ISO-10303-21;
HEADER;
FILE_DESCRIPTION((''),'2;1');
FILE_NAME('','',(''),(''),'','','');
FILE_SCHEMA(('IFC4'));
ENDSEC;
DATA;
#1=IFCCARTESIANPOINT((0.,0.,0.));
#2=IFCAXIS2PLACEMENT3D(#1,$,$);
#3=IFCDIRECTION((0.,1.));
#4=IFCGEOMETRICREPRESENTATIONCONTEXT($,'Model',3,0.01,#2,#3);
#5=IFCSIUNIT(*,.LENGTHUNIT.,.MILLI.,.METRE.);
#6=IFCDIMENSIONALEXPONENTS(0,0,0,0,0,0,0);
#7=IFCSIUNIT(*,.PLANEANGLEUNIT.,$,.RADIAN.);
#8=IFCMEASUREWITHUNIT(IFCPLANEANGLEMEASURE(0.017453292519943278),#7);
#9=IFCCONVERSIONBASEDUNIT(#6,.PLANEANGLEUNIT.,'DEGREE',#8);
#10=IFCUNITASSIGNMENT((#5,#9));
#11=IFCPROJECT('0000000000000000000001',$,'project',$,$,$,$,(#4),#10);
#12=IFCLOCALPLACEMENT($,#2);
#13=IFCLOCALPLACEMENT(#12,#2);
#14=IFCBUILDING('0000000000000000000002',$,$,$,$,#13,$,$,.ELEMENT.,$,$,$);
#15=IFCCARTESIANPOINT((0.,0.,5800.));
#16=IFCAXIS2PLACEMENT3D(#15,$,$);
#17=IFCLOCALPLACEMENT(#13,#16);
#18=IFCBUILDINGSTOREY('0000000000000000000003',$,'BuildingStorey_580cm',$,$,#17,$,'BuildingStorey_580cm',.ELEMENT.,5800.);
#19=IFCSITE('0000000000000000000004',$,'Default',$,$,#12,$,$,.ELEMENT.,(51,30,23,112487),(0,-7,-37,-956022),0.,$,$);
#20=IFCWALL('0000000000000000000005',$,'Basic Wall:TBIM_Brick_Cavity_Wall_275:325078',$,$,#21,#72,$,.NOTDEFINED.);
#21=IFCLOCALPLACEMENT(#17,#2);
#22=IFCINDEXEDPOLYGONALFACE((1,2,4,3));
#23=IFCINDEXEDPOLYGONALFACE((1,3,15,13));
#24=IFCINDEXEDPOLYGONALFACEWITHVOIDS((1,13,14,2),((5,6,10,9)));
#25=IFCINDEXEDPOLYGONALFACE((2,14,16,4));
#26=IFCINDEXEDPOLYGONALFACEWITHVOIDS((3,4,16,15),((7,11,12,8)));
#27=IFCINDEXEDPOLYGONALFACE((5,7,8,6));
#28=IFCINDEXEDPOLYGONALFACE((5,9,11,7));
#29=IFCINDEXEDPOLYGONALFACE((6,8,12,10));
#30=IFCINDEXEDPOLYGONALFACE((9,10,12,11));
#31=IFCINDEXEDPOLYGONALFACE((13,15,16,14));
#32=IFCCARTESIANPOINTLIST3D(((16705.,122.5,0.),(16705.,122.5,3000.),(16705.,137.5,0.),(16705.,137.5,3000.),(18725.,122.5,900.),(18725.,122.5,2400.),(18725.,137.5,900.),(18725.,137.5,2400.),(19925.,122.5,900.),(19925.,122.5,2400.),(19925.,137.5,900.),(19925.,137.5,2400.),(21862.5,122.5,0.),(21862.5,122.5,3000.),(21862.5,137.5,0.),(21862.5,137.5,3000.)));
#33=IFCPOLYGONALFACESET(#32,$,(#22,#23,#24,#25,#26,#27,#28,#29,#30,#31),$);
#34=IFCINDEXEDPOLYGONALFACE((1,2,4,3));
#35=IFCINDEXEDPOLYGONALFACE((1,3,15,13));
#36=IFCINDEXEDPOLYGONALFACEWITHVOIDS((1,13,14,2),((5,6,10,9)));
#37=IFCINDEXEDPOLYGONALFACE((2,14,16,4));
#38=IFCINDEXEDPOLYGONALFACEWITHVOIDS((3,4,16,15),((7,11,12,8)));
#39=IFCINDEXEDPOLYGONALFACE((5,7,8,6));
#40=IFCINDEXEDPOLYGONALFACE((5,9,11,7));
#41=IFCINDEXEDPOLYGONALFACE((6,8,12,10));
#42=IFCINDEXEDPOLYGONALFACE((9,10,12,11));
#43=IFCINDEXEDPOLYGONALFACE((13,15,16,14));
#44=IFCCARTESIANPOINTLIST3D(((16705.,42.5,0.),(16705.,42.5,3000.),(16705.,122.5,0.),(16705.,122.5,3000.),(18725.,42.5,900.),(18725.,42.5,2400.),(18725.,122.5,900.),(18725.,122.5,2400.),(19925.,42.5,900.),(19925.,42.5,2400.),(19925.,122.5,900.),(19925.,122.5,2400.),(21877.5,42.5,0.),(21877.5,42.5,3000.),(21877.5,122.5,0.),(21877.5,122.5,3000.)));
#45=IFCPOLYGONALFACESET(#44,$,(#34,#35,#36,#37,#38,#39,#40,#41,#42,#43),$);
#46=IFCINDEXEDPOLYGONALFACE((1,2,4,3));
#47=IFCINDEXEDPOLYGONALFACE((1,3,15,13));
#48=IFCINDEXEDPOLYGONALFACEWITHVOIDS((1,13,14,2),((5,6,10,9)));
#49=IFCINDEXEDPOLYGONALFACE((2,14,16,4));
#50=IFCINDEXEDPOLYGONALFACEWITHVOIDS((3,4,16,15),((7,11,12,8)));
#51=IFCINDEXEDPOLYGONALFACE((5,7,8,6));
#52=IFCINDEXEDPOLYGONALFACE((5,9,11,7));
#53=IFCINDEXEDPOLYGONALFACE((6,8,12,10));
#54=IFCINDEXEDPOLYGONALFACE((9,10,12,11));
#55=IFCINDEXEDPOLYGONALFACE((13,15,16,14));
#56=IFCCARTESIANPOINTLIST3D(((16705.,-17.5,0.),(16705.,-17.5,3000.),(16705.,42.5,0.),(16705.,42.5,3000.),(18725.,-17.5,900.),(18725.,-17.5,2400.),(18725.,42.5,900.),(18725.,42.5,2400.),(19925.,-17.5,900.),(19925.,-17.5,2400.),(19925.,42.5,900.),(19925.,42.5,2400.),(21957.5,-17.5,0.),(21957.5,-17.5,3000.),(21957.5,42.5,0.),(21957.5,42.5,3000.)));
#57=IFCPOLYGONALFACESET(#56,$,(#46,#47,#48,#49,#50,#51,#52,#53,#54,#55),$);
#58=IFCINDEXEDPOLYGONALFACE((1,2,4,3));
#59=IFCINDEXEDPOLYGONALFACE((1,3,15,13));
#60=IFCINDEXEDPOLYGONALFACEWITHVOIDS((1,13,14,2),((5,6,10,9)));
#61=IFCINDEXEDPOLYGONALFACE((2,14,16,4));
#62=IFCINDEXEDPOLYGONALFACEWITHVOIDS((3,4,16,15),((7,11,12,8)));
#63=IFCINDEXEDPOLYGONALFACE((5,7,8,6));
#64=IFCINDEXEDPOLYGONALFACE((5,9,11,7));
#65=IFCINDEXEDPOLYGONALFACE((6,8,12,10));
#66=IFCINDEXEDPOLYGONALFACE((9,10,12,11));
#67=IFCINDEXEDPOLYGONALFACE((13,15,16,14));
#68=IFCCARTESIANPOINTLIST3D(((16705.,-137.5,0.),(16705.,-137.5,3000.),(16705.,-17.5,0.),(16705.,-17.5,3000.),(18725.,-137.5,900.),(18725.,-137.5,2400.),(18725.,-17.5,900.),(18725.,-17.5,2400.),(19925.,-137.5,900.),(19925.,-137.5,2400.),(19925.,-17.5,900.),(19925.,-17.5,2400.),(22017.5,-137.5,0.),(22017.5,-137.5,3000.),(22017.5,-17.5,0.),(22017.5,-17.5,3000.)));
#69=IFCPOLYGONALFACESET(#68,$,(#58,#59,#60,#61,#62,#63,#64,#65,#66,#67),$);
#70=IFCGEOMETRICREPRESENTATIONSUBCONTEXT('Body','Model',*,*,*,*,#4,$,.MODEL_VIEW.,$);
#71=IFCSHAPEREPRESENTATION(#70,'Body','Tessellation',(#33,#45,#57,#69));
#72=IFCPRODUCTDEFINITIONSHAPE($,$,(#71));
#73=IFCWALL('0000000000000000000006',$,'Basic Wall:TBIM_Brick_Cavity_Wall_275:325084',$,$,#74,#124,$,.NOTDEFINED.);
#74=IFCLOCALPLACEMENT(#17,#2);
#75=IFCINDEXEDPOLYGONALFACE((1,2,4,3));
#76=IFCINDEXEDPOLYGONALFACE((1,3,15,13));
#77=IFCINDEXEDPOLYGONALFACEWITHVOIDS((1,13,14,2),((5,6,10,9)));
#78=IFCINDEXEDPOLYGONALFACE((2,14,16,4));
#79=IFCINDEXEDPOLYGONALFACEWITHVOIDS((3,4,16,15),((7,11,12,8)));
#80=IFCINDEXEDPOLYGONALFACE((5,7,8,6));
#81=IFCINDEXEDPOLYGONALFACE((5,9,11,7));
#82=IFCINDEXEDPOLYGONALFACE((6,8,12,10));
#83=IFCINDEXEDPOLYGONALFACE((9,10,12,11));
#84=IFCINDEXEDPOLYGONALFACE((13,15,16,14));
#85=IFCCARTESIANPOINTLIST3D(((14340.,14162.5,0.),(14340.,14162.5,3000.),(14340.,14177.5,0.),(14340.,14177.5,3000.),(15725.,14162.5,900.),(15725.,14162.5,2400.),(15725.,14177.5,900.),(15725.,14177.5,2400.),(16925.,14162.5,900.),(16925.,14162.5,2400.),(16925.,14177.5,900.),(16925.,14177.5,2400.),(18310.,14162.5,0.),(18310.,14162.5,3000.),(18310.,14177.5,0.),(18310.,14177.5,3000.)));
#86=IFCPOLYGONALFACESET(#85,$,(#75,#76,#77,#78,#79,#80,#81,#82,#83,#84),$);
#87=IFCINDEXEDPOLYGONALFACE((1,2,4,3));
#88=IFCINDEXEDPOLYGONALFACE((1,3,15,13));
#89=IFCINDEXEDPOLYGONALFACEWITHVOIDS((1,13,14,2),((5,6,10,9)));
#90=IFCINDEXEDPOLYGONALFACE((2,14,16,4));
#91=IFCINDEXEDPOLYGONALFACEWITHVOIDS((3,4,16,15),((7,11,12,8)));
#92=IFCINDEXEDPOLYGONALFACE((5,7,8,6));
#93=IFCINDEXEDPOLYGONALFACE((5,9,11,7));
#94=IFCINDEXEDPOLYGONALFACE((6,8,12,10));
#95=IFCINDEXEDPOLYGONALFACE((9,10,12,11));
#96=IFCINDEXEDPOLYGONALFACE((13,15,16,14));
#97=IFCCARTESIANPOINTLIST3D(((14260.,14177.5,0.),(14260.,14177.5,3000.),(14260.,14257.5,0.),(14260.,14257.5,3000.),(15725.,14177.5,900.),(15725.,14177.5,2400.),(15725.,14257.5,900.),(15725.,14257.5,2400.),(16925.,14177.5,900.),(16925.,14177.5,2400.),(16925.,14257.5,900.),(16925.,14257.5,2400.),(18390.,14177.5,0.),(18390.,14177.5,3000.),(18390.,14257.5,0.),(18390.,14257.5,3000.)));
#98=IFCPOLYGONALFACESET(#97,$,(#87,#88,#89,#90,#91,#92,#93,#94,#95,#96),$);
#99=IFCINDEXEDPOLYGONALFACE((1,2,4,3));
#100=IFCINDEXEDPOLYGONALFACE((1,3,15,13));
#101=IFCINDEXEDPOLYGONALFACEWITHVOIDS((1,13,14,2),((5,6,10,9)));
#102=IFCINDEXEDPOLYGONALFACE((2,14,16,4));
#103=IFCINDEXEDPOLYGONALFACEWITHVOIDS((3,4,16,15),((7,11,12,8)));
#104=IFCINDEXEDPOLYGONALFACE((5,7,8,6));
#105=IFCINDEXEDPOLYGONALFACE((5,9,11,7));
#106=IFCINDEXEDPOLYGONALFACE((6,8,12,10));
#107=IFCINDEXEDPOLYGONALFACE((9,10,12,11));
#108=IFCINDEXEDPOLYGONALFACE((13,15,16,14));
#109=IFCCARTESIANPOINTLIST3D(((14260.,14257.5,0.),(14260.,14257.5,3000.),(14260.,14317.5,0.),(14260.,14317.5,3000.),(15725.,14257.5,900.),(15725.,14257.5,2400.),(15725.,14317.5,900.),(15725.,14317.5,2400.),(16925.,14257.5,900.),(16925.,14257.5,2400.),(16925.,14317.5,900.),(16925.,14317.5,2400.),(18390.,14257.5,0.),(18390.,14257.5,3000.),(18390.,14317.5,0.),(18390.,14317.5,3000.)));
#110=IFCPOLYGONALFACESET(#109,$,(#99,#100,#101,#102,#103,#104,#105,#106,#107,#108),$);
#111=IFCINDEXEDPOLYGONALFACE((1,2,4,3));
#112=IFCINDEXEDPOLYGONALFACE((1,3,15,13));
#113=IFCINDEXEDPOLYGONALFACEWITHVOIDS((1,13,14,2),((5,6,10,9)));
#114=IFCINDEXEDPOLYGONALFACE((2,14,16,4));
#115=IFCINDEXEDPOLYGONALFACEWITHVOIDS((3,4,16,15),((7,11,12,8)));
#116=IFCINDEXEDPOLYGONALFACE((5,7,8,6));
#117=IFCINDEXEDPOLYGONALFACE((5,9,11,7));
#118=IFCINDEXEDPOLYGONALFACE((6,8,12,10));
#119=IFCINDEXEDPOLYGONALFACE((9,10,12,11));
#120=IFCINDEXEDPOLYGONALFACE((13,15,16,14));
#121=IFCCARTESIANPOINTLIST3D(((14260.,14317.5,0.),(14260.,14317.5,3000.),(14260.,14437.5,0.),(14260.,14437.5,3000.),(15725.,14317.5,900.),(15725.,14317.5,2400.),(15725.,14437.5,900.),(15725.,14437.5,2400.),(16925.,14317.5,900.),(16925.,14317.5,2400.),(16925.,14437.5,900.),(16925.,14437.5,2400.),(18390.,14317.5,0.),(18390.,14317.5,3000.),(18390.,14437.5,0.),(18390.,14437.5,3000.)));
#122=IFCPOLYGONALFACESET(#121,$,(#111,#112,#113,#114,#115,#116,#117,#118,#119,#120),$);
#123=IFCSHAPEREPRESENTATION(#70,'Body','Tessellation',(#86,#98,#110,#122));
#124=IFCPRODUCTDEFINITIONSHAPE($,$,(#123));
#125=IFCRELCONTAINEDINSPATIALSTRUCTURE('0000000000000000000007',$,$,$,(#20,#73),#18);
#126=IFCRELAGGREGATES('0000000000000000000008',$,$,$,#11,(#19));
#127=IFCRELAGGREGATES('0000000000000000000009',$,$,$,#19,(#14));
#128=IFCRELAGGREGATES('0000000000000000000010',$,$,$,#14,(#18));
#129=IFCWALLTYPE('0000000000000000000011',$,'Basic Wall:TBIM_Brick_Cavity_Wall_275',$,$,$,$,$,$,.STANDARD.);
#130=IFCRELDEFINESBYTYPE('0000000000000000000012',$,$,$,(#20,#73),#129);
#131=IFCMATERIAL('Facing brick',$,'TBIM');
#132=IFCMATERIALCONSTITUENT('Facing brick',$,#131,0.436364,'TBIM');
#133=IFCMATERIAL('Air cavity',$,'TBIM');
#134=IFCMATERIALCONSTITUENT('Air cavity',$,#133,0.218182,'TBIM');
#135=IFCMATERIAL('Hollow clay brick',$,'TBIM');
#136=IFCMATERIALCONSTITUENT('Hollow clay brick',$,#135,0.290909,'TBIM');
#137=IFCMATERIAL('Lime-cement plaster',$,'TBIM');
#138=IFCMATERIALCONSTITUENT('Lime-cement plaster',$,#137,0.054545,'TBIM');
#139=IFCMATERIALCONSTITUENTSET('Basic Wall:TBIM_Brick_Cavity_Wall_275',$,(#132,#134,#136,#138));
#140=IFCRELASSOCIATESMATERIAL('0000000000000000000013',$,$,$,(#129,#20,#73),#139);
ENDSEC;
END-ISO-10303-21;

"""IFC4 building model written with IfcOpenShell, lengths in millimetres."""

from ifc_helpers import new_model, entity, si_unit, converted_unit, direction, frame, origin, place, context, subcontext, project, spatial, indexed_curve, outline, extrude, material, constituent, constituent_set, type_object, element, save


model = new_model("IFC4")

# Units and contexts
model_context = context("Model", 3, precision=0.01, world=origin(), true_north=direction((0.0, 1.0)))
body_context = subcontext(model_context, "Body", "Model", "MODEL_VIEW")
ifc_project = project(units=[si_unit("LENGTHUNIT", "METRE", prefix="MILLI"), converted_unit("PLANEANGLEUNIT", "DEGREE", entity("IfcPlaneAngleMeasure", 0.017453292519943278), si_unit("PLANEANGLEUNIT", "RADIAN"), dimensions=[0, 0, 0, 0, 0, 0, 0])], contexts=[model_context])

# Site, building, storey
site_placement = place(None, origin())
site = spatial("IfcSite", under=ifc_project, at=site_placement, Name="Default", CompositionType="ELEMENT", RefLatitude=(51, 30, 23, 112487), RefLongitude=(0, -7, -37, -956022), RefElevation=0.0)
building_placement = place(site_placement, origin())
building = spatial("IfcBuilding", under=site, at=building_placement, CompositionType="ELEMENT")
storey_placement = place(building_placement, frame((0.0, 0.0, 5800.0)))
storey = spatial("IfcBuildingStorey", under=building, at=storey_placement, Name="BuildingStorey_580cm", LongName="BuildingStorey_580cm", CompositionType="ELEMENT", Elevation=5800.0)

# Walls, openings
ifc_material_1 = material(Name="Facing brick", Category="TBIM")
ifc_constituent_1 = constituent(ifc_material_1, Name="Facing brick", Category="TBIM", fraction=0.436364)
ifc_material_2 = material(Name="Air cavity", Category="TBIM")
ifc_constituent_2 = constituent(ifc_material_2, Name="Air cavity", Category="TBIM", fraction=0.218182)
ifc_material_3 = material(Name="Hollow clay brick", Category="TBIM")
ifc_constituent_3 = constituent(ifc_material_3, Name="Hollow clay brick", Category="TBIM", fraction=0.290909)
ifc_material_4 = material(Name="Lime-cement plaster", Category="TBIM")
ifc_constituent_4 = constituent(ifc_material_4, Name="Lime-cement plaster", Category="TBIM", fraction=0.054545)
ifc_constituent_set_1 = constituent_set(constituents=[ifc_constituent_1, ifc_constituent_2, ifc_constituent_3, ifc_constituent_4], Name="Basic Wall:TBIM_Brick_Cavity_Wall_275")
wall_type_1 = type_object("IfcWallType", Name="Basic Wall:TBIM_Brick_Cavity_Wall_275", PredefinedType="STANDARD", material=ifc_constituent_set_1)
wall_1_placement = place(storey_placement, frame((16705.0, 0.0, 0.0)))
wall_1 = element("IfcWall", 1, at=wall_1_placement, inside=storey, type_object=wall_type_1, material=ifc_constituent_set_1, Name="Basic Wall:TBIM_Brick_Cavity_Wall_275:325078", PredefinedType="NOTDEFINED", context=body_context, shape_type="SweptSolid", body=[
    extrude(outline(indexed_curve([(-1500.0, -2578.8), (1500.0, -2578.8), (1500.0, 2578.8), (-1500.0, 2578.8), (-1500.0, -2578.8)], self_intersect=False), holes=[indexed_curve([(-600.0, -558.8), (-600.0, 641.2), (900.0, 641.2), (900.0, -558.8), (-600.0, -558.8)], self_intersect=False)]), frame((2578.8, 122.5, 1500.0), z_axis=(0.0, 1.0, 0.0), x_axis=(0.0, 0.0, 1.0)), (0.0, 0.0, 1.0), 15.0),
    extrude(outline(indexed_curve([(-1500.0, -2586.3), (1500.0, -2586.3), (1500.0, 2586.3), (-1500.0, 2586.3), (-1500.0, -2586.3)], self_intersect=False), holes=[indexed_curve([(-600.0, -566.3), (-600.0, 633.7), (900.0, 633.7), (900.0, -566.3), (-600.0, -566.3)], self_intersect=False)]), frame((2586.3, 42.5, 1500.0), z_axis=(0.0, 1.0, 0.0), x_axis=(0.0, 0.0, 1.0)), (0.0, 0.0, 1.0), 80.0),
    extrude(outline(indexed_curve([(-1500.0, -2626.3), (1500.0, -2626.3), (1500.0, 2626.3), (-1500.0, 2626.3), (-1500.0, -2626.3)], self_intersect=False), holes=[indexed_curve([(-600.0, -606.3), (-600.0, 593.7), (900.0, 593.7), (900.0, -606.3), (-600.0, -606.3)], self_intersect=False)]), frame((2626.3, -17.5, 1500.0), z_axis=(0.0, 1.0, 0.0), x_axis=(0.0, 0.0, 1.0)), (0.0, 0.0, 1.0), 60.0),
    extrude(outline(indexed_curve([(-1500.0, -2656.3), (1500.0, -2656.3), (1500.0, 2656.3), (-1500.0, 2656.3), (-1500.0, -2656.3)], self_intersect=False), holes=[indexed_curve([(900.0, -636.3), (-600.0, -636.3), (-600.0, 563.7), (900.0, 563.7), (900.0, -636.3)], self_intersect=False)]), frame((2656.3, -137.5, 1500.0), z_axis=(0.0, 1.0, 0.0), x_axis=(0.0, 0.0, 1.0)), (0.0, 0.0, 1.0), 120.0),
])
opening_1_placement = place(wall_1_placement, frame((2020.0, -137.5, 900.0)))
element("IfcOpeningElement", 2, at=opening_1_placement, cuts=wall_1, PredefinedType="OPENING", context=body_context, shape_type="SweptSolid", body=[
    extrude(outline(indexed_curve([(1500.0, 0.0), (1500.0, 1200.0), (0.0, 1200.0), (0.0, 0.0), (1500.0, 0.0)], self_intersect=False)), frame((0.0, 0.0, 0.0), z_axis=(0.0, 1.0, 0.0), x_axis=(0.0, 0.0, 1.0)), (0.0, 0.0, 1.0), 275.0),
])
wall_2_placement = place(storey_placement, frame((14245.0, 14300.0, 0.0)))
wall_2 = element("IfcWall", 3, at=wall_2_placement, inside=storey, type_object=wall_type_1, material=ifc_constituent_set_1, Name="Basic Wall:TBIM_Brick_Cavity_Wall_275:325084", PredefinedType="NOTDEFINED", context=body_context, shape_type="SweptSolid", body=[
    extrude(outline(indexed_curve([(-1500.0, -1985.0), (1500.0, -1985.0), (1500.0, -1970.0), (1500.0, 1970.0), (1500.0, 1985.0), (-1500.0, 1985.0), (-1500.0, 1970.0), (-1500.0, -1970.0), (-1500.0, -1985.0)], self_intersect=False), holes=[indexed_curve([(900.0, -600.0), (-600.0, -600.0), (-600.0, 600.0), (900.0, 600.0), (900.0, -600.0)], self_intersect=False)]), frame((2080.0, -137.5, 1500.0), z_axis=(0.0, 1.0, 0.0), x_axis=(0.0, 0.0, 1.0)), (0.0, 0.0, 1.0), 15.0),
    extrude(outline(indexed_curve([(-1500.0, -2065.0), (1500.0, -2065.0), (1500.0, 2065.0), (-1500.0, 2065.0), (-1500.0, -2065.0)], self_intersect=False), holes=[indexed_curve([(-600.0, -600.0), (-600.0, 600.0), (900.0, 600.0), (900.0, -600.0), (-600.0, -600.0)], self_intersect=False)]), frame((2080.0, -122.5, 1500.0), z_axis=(0.0, 1.0, 0.0), x_axis=(0.0, 0.0, 1.0)), (0.0, 0.0, 1.0), 80.0),
    extrude(outline(indexed_curve([(-1500.0, -2065.0), (1500.0, -2065.0), (1500.0, 2065.0), (-1500.0, 2065.0), (-1500.0, -2065.0)], self_intersect=False), holes=[indexed_curve([(-600.0, -600.0), (-600.0, 600.0), (900.0, 600.0), (900.0, -600.0), (-600.0, -600.0)], self_intersect=False)]), frame((2080.0, -42.5, 1500.0), z_axis=(0.0, 1.0, 0.0), x_axis=(0.0, 0.0, 1.0)), (0.0, 0.0, 1.0), 60.0),
    extrude(outline(indexed_curve([(-1500.0, -2065.0), (1500.0, -2065.0), (1500.0, 2065.0), (-1500.0, 2065.0), (-1500.0, -2065.0)], self_intersect=False), holes=[indexed_curve([(-600.0, -600.0), (-600.0, 600.0), (900.0, 600.0), (900.0, -600.0), (-600.0, -600.0)], self_intersect=False)]), frame((2080.0, 17.5, 1500.0), z_axis=(0.0, 1.0, 0.0), x_axis=(0.0, 0.0, 1.0)), (0.0, 0.0, 1.0), 120.0),
])
opening_2_placement = place(wall_2_placement, frame((1480.0, -137.5, 900.0)))
element("IfcOpeningElement", 4, at=opening_2_placement, cuts=wall_2, PredefinedType="OPENING", context=body_context, shape_type="SweptSolid", body=[
    extrude(outline(indexed_curve([(1500.0, 0.0), (1500.0, 1200.0), (0.0, 1200.0), (0.0, 0.0), (1500.0, 0.0)], self_intersect=False)), frame((0.0, 0.0, 0.0), z_axis=(0.0, 1.0, 0.0), x_axis=(0.0, 0.0, 1.0)), (0.0, 0.0, 1.0), 275.0),
])

save(model, "model.ifc")
